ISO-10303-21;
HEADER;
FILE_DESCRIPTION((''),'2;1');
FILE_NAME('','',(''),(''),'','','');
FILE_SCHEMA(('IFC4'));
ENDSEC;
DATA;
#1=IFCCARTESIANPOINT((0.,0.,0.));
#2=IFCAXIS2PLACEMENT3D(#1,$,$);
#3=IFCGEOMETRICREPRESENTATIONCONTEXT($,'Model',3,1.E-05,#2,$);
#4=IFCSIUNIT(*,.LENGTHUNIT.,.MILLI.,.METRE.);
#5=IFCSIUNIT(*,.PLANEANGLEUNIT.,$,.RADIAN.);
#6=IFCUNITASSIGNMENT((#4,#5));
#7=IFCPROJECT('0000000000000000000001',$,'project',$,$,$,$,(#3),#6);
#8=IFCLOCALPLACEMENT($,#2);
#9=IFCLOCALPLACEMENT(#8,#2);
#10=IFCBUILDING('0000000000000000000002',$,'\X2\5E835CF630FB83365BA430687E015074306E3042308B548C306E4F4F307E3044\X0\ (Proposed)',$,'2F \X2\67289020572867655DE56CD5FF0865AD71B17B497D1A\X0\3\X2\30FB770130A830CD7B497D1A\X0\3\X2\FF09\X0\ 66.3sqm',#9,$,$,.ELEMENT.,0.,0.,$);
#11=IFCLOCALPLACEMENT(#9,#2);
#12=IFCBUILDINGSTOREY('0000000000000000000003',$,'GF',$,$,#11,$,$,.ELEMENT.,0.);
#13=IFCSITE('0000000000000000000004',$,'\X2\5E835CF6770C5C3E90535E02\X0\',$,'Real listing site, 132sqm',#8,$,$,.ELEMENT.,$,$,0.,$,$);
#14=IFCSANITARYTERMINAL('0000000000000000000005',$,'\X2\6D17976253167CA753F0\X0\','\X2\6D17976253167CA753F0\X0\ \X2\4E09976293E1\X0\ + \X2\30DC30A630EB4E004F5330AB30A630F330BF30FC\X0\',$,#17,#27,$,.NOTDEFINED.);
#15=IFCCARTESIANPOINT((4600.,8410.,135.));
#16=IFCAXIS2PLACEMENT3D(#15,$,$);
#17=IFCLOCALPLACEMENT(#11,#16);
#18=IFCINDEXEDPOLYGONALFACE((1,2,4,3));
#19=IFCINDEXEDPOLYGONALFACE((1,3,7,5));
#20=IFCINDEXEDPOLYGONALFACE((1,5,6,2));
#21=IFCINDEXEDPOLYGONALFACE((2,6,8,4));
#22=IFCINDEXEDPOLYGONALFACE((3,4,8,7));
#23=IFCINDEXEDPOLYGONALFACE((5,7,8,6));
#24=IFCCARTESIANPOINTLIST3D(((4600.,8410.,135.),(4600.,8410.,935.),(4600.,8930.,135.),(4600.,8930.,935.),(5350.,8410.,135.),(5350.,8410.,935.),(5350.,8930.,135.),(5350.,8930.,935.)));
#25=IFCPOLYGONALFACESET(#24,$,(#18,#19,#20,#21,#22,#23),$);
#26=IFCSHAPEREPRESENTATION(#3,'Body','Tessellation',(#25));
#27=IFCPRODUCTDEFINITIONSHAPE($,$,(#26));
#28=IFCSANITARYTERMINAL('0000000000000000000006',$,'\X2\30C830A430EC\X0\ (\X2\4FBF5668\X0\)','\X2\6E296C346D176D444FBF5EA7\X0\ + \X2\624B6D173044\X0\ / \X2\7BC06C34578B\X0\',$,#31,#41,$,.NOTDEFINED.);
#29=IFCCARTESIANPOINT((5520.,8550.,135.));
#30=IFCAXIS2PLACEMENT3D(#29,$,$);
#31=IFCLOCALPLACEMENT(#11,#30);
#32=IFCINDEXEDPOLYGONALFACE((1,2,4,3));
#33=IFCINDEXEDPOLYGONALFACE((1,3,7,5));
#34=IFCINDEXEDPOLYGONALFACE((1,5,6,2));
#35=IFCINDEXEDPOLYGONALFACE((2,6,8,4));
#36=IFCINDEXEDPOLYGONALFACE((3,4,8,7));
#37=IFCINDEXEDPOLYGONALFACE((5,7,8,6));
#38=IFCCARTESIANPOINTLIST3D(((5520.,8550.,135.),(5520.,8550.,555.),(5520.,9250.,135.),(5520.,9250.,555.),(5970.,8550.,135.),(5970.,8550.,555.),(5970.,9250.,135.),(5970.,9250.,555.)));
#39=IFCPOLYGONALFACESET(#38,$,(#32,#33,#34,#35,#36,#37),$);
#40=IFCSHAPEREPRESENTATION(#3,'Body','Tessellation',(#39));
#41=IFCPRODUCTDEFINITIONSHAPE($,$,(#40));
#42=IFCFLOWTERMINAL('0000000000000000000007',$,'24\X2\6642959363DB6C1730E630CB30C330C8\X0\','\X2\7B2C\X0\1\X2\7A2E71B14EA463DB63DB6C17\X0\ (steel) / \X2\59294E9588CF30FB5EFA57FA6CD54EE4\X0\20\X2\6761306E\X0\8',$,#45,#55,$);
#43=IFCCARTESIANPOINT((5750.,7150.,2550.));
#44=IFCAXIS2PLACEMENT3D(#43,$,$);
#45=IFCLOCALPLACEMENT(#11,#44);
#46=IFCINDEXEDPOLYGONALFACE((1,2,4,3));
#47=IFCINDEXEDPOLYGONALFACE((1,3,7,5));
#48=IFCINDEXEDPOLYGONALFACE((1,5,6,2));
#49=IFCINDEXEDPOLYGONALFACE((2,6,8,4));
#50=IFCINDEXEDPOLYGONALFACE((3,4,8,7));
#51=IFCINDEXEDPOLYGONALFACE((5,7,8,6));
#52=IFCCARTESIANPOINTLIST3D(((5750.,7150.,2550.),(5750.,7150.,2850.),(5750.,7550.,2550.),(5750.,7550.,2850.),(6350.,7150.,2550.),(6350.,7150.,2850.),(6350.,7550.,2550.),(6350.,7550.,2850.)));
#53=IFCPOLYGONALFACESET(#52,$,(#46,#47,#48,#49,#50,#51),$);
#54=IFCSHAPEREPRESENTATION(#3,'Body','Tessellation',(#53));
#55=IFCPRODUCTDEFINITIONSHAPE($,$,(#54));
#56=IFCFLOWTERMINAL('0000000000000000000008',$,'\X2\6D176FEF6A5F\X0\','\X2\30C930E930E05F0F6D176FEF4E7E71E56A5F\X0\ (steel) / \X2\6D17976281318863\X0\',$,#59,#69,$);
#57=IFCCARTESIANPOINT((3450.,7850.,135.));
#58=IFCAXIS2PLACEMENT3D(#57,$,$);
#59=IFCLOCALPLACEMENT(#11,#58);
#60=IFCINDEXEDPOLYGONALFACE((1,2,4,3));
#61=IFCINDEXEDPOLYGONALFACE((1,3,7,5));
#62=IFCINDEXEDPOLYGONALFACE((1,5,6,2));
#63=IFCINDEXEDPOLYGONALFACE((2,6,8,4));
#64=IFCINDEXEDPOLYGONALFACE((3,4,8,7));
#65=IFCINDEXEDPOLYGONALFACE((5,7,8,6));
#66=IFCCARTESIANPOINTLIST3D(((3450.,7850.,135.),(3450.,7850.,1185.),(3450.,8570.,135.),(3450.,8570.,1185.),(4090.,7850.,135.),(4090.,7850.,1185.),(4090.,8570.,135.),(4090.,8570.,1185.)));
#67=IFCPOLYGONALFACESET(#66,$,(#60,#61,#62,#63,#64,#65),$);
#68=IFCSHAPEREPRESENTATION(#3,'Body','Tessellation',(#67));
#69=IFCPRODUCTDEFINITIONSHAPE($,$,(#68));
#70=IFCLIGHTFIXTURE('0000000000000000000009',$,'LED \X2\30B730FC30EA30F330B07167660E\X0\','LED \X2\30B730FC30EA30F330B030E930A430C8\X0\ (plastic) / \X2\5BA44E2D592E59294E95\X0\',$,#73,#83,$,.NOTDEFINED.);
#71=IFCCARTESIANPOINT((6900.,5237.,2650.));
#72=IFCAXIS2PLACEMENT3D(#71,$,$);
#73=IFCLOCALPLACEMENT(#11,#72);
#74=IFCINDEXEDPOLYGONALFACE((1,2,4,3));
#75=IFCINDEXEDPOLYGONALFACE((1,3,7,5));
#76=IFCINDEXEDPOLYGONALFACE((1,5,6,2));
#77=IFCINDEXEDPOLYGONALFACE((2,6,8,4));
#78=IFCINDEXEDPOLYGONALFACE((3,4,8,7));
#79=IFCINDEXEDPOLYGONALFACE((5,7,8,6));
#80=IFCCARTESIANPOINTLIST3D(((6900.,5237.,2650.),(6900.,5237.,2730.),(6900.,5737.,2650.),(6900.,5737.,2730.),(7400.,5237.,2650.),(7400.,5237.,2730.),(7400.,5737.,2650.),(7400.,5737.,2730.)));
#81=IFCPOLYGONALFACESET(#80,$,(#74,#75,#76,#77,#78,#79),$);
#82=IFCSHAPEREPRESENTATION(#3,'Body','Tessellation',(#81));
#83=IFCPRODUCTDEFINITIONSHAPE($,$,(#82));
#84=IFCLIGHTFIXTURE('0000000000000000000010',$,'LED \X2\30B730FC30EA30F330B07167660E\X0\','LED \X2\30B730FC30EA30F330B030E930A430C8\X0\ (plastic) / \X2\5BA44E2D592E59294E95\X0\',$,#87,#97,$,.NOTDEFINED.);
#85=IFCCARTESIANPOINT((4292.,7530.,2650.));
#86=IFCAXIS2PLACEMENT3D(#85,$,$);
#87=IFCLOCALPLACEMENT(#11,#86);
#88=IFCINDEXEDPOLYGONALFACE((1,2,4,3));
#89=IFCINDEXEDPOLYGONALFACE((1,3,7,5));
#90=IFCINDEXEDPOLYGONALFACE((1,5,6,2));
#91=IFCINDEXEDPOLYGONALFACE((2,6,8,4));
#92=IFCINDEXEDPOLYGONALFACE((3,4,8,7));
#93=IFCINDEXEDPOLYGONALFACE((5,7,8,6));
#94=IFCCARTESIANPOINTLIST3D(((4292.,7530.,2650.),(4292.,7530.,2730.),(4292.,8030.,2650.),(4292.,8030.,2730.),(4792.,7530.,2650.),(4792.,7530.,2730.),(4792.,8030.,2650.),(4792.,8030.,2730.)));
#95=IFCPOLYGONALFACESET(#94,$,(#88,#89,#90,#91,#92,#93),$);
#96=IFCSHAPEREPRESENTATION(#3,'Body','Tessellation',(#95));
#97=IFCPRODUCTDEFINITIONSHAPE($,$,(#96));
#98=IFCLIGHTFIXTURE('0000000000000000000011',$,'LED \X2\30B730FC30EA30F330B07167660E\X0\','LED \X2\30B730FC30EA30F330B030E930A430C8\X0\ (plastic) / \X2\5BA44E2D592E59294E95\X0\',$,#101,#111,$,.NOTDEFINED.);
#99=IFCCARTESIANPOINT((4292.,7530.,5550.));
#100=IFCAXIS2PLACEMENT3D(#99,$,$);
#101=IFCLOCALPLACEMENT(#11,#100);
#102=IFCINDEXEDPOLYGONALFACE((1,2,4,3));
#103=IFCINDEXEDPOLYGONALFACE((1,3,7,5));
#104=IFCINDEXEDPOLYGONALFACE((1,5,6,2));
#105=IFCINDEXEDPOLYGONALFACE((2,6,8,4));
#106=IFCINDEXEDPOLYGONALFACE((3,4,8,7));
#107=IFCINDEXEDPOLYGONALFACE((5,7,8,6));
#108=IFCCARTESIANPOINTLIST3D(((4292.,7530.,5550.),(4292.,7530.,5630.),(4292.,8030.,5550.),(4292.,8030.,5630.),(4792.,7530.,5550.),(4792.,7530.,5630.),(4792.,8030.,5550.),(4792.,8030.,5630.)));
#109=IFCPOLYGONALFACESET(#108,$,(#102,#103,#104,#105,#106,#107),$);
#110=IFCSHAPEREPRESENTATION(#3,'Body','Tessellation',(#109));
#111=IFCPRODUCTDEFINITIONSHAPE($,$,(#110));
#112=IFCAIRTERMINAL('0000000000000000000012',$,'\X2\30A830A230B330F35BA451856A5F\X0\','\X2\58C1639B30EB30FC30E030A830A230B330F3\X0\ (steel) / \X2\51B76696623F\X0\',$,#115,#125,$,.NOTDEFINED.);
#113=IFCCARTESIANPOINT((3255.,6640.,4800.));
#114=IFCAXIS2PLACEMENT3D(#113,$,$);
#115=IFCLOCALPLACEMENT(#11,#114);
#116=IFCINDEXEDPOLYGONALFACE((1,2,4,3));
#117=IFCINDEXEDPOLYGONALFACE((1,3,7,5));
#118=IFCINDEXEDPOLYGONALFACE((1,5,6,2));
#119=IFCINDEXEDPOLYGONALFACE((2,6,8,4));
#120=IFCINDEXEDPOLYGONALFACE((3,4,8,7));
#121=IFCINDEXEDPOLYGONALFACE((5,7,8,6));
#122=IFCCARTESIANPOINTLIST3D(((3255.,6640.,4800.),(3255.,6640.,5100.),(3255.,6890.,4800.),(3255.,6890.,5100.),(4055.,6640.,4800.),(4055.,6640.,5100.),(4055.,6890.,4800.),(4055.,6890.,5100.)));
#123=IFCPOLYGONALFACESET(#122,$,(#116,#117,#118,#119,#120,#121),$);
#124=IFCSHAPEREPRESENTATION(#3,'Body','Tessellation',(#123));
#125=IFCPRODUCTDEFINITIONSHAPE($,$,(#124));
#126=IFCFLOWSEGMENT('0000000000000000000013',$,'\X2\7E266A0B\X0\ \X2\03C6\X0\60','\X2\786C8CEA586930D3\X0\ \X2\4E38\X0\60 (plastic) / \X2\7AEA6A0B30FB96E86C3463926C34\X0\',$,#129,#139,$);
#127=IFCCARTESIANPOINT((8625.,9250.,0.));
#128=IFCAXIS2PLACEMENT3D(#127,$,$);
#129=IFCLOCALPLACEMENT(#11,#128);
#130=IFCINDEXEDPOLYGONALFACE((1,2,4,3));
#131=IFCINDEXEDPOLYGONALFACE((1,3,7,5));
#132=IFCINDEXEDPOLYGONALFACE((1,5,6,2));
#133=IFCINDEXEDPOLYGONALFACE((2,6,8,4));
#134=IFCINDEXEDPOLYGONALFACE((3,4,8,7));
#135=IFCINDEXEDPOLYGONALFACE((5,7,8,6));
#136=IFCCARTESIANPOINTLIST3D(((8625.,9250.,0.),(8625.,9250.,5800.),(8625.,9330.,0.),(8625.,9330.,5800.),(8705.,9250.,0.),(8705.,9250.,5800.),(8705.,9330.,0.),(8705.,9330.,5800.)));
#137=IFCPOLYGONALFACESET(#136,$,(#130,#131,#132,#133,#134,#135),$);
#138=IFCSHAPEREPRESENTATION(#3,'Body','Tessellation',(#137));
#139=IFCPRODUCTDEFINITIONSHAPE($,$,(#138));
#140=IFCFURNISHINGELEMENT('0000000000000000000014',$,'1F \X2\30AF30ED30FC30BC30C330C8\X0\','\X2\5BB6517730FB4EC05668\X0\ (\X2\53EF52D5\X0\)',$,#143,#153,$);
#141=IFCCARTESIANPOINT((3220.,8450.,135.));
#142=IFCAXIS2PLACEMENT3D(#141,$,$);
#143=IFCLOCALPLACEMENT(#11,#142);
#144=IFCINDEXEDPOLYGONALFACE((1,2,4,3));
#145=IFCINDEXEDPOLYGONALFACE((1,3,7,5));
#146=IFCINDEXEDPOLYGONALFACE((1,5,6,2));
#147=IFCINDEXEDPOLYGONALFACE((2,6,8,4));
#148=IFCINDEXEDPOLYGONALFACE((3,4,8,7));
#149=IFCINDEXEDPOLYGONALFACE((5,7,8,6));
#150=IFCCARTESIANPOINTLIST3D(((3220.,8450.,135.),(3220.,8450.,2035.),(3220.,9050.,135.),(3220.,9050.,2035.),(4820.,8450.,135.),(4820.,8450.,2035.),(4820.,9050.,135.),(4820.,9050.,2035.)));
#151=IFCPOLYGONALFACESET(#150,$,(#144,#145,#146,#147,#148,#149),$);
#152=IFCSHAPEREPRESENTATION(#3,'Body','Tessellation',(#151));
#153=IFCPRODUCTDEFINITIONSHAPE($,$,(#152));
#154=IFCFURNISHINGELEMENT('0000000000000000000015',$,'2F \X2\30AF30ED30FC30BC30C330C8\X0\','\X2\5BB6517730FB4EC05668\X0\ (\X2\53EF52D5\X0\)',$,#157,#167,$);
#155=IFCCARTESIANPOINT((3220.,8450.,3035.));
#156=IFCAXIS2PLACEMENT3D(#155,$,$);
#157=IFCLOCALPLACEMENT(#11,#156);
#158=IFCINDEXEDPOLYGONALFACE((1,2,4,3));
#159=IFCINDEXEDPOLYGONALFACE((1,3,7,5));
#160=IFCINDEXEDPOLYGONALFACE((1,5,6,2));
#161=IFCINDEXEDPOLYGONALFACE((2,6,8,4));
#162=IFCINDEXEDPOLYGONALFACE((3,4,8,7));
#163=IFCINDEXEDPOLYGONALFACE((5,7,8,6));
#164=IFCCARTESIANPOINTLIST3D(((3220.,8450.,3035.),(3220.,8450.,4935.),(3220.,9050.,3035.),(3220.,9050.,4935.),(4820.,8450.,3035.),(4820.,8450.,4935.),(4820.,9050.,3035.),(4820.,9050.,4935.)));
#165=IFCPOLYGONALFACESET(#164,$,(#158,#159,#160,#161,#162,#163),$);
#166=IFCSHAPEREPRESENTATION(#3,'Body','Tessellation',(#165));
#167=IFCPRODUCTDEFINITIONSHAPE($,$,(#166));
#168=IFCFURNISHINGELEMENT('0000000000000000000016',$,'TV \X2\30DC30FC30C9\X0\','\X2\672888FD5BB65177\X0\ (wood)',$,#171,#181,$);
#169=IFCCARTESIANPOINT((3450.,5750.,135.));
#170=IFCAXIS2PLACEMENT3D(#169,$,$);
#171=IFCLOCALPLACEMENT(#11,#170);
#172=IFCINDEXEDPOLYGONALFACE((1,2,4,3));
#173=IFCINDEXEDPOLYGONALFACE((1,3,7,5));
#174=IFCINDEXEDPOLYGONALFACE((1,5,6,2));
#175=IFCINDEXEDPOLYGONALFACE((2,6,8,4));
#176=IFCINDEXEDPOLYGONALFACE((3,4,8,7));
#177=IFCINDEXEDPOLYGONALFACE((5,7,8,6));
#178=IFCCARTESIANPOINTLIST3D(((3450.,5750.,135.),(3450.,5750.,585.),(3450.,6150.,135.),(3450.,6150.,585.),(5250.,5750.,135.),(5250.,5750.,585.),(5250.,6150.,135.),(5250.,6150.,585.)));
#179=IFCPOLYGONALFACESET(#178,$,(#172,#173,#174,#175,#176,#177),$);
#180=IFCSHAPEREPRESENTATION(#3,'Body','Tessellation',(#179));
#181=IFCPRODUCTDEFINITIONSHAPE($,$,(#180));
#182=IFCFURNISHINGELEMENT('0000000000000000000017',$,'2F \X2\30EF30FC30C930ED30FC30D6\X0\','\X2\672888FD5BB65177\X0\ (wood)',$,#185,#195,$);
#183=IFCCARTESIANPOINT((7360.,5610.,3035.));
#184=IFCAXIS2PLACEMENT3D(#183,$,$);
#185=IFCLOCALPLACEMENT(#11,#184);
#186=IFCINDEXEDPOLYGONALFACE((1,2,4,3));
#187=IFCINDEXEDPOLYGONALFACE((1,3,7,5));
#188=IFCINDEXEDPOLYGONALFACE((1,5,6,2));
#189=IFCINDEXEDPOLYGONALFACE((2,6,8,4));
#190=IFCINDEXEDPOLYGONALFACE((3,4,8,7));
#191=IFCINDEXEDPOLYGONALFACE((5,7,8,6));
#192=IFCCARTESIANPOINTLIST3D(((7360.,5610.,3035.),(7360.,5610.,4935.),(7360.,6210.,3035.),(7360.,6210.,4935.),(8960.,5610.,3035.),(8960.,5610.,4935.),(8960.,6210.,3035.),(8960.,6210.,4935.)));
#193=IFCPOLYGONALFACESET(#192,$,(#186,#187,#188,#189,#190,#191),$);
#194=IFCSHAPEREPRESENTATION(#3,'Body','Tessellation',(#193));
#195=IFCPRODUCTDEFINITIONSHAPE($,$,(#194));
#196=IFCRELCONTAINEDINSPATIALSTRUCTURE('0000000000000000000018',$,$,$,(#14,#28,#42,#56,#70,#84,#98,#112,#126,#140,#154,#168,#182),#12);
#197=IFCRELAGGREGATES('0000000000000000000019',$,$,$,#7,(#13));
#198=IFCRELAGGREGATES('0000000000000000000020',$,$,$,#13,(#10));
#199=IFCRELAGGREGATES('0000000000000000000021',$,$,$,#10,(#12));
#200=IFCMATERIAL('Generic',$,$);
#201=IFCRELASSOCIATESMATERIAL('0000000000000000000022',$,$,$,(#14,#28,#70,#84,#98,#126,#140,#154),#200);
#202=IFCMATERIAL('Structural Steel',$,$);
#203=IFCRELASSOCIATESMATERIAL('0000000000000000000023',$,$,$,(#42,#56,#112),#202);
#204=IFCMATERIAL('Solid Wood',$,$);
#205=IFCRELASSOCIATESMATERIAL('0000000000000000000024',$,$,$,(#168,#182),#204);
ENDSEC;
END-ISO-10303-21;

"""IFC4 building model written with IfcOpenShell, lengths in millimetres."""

from ifc_helpers import new_model, si_unit, frame, frame_2d, origin, place, context, project, spatial, rectangle, extrude, material, element, save


model = new_model("IFC4")

# Units and contexts
model_context = context("Model", 3, precision=1e-05, world=origin())
ifc_project = project(units=[si_unit("LENGTHUNIT", "METRE", prefix="MILLI"), si_unit("PLANEANGLEUNIT", "RADIAN")], contexts=[model_context])

# Site, building, storey
site_placement = place(None, origin())
site = spatial("IfcSite", under=ifc_project, at=site_placement, Name="広島県尾道市", ObjectType="Real listing site, 132sqm", CompositionType="ELEMENT", RefElevation=0.0)
building_placement = place(site_placement, origin())
building = spatial("IfcBuilding", under=site, at=building_placement, Name="広島・茶室と縁側のある和の住まい (Proposed)", ObjectType="2F 木造在来工法（断熱等級3・省エネ等級3） 66.3sqm", CompositionType="ELEMENT", ElevationOfRefHeight=0.0, ElevationOfTerrain=0.0)
storey_placement = place(building_placement, origin())
storey = spatial("IfcBuildingStorey", under=building, at=storey_placement, Name="GF", CompositionType="ELEMENT", Elevation=0.0)

# Shared definitions
ifc_material_1 = material(Name="Solid Wood")

# Sanitary terminals
ifc_material_2 = material(Name="Generic")
sanitary_terminal_1_placement = place(storey_placement, frame((4600.0, 8410.0, 135.0)))
element("IfcSanitaryTerminal", 1, at=sanitary_terminal_1_placement, inside=storey, material=ifc_material_2, Name="洗面化粧台", Description="洗面化粧台 三面鏡 + ボウル一体カウンター", PredefinedType="NOTDEFINED", context=model_context, shape_type="SweptSolid", body=[
    extrude(rectangle(XDim=750.0, YDim=520.0, at=frame_2d((375.0, 260.0))), frame((4600.0, 8410.0, 135.0)), (0.0, 0.0, 1.0), 800.0),
])
sanitary_terminal_2_placement = place(storey_placement, frame((5520.0, 8550.0, 135.0)))
element("IfcSanitaryTerminal", 2, at=sanitary_terminal_2_placement, inside=storey, material=ifc_material_2, Name="トイレ (便器)", Description="温水洗浄便座 + 手洗い / 節水型", PredefinedType="NOTDEFINED", context=model_context, shape_type="SweptSolid", body=[
    extrude(rectangle(XDim=450.0, YDim=700.0, at=frame_2d((225.0, 350.0))), frame((5520.0, 8550.0, 135.0)), (0.0, 0.0, 1.0), 420.0),
])

# Flow terminals
ifc_material_3 = material(Name="Structural Steel")
flow_terminal_1_placement = place(storey_placement, frame((5750.0, 7150.0, 2550.0)))
element("IfcFlowTerminal", 3, at=flow_terminal_1_placement, inside=storey, material=ifc_material_3, Name="24時間換気ユニット", Description="第1種熱交換換気 (steel) / 天井裏・建基法令20条の8", context=model_context, shape_type="SweptSolid", body=[
    extrude(rectangle(XDim=600.0, YDim=400.0, at=frame_2d((300.0, 200.0))), frame((5750.0, 7150.0, 2550.0)), (0.0, 0.0, 1.0), 300.0),
])
flow_terminal_2_placement = place(storey_placement, frame((3450.0, 7850.0, 135.0)))
element("IfcFlowTerminal", 4, at=flow_terminal_2_placement, inside=storey, material=ifc_material_3, Name="洗濯機", Description="ドラム式洗濯乾燥機 (steel) / 洗面脱衣", context=model_context, shape_type="SweptSolid", body=[
    extrude(rectangle(XDim=640.0, YDim=720.0, at=frame_2d((320.0, 360.0))), frame((3450.0, 7850.0, 135.0)), (0.0, 0.0, 1.0), 1050.0),
])

# Light fixtures
light_fixture_1_placement = place(storey_placement, frame((6900.0, 5237.0, 2650.0)))
element("IfcLightFixture", 5, at=light_fixture_1_placement, inside=storey, material=ifc_material_2, Name="LED シーリング照明", Description="LED シーリングライト (plastic) / 室中央天井", PredefinedType="NOTDEFINED", context=model_context, shape_type="SweptSolid", body=[
    extrude(rectangle(XDim=500.0, YDim=500.0, at=frame_2d((250.0, 250.0))), frame((6900.0, 5237.0, 2650.0)), (0.0, 0.0, 1.0), 80.0),
])
light_fixture_2_placement = place(storey_placement, frame((4292.0, 7530.0, 2650.0)))
element("IfcLightFixture", 6, at=light_fixture_2_placement, inside=storey, material=ifc_material_2, Name="LED シーリング照明", Description="LED シーリングライト (plastic) / 室中央天井", PredefinedType="NOTDEFINED", context=model_context, shape_type="SweptSolid", body=[
    extrude(rectangle(XDim=500.0, YDim=500.0, at=frame_2d((250.0, 250.0))), frame((4292.0, 7530.0, 2650.0)), (0.0, 0.0, 1.0), 80.0),
])
light_fixture_3_placement = place(storey_placement, frame((4292.0, 7530.0, 5550.0)))
element("IfcLightFixture", 7, at=light_fixture_3_placement, inside=storey, material=ifc_material_2, Name="LED シーリング照明", Description="LED シーリングライト (plastic) / 室中央天井", PredefinedType="NOTDEFINED", context=model_context, shape_type="SweptSolid", body=[
    extrude(rectangle(XDim=500.0, YDim=500.0, at=frame_2d((250.0, 250.0))), frame((4292.0, 7530.0, 5550.0)), (0.0, 0.0, 1.0), 80.0),
])

# Air terminal
air_terminal_placement = place(storey_placement, frame((3255.0, 6640.0, 4800.0)))
element("IfcAirTerminal", 8, at=air_terminal_placement, inside=storey, material=ifc_material_3, Name="エアコン室内機", Description="壁掛ルームエアコン (steel) / 冷暖房", PredefinedType="NOTDEFINED", context=model_context, shape_type="SweptSolid", body=[
    extrude(rectangle(XDim=800.0, YDim=250.0, at=frame_2d((400.0, 125.0))), frame((3255.0, 6640.0, 4800.0)), (0.0, 0.0, 1.0), 300.0),
])

# Flow segment
flow_segment_placement = place(storey_placement, frame((8625.0, 9250.0, 0.0)))
element("IfcFlowSegment", 9, at=flow_segment_placement, inside=storey, material=ifc_material_2, Name="縦樋 φ60", Description="硬質塩ビ 丸60 (plastic) / 竪樋・雨水排水", context=model_context, shape_type="SweptSolid", body=[
    extrude(rectangle(XDim=80.0, YDim=80.0, at=frame_2d((40.0, 40.0))), frame((8625.0, 9250.0, 0.0)), (0.0, 0.0, 1.0), 5800.0),
])

# Furnishing elements
furnishing_1_placement = place(storey_placement, frame((3220.0, 8450.0, 135.0)))
element("IfcFurnishingElement", 10, at=furnishing_1_placement, inside=storey, material=ifc_material_2, Name="1F クローゼット", Description="家具・什器 (可動)", context=model_context, shape_type="SweptSolid", body=[
    extrude(rectangle(XDim=1600.0, YDim=600.0, at=frame_2d((800.0, 300.0))), frame((3220.0, 8450.0, 135.0)), (0.0, 0.0, 1.0), 1900.0),
])
furnishing_2_placement = place(storey_placement, frame((3220.0, 8450.0, 3035.0)))
element("IfcFurnishingElement", 11, at=furnishing_2_placement, inside=storey, material=ifc_material_2, Name="2F クローゼット", Description="家具・什器 (可動)", context=model_context, shape_type="SweptSolid", body=[
    extrude(rectangle(XDim=1600.0, YDim=600.0, at=frame_2d((800.0, 300.0))), frame((3220.0, 8450.0, 3035.0)), (0.0, 0.0, 1.0), 1900.0),
])
furnishing_3_placement = place(storey_placement, frame((3450.0, 5750.0, 135.0)))
element("IfcFurnishingElement", 12, at=furnishing_3_placement, inside=storey, material=ifc_material_1, Name="TV ボード", Description="木製家具 (wood)", context=model_context, shape_type="SweptSolid", body=[
    extrude(rectangle(XDim=1800.0, YDim=400.0, at=frame_2d((900.0, 200.0))), frame((3450.0, 5750.0, 135.0)), (0.0, 0.0, 1.0), 450.0),
])
furnishing_4_placement = place(storey_placement, frame((7360.0, 5610.0, 3035.0)))
element("IfcFurnishingElement", 13, at=furnishing_4_placement, inside=storey, material=ifc_material_1, Name="2F ワードローブ", Description="木製家具 (wood)", context=model_context, shape_type="SweptSolid", body=[
    extrude(rectangle(XDim=1600.0, YDim=600.0, at=frame_2d((800.0, 300.0))), frame((7360.0, 5610.0, 3035.0)), (0.0, 0.0, 1.0), 1900.0),
])

save(model, "model.ifc")
